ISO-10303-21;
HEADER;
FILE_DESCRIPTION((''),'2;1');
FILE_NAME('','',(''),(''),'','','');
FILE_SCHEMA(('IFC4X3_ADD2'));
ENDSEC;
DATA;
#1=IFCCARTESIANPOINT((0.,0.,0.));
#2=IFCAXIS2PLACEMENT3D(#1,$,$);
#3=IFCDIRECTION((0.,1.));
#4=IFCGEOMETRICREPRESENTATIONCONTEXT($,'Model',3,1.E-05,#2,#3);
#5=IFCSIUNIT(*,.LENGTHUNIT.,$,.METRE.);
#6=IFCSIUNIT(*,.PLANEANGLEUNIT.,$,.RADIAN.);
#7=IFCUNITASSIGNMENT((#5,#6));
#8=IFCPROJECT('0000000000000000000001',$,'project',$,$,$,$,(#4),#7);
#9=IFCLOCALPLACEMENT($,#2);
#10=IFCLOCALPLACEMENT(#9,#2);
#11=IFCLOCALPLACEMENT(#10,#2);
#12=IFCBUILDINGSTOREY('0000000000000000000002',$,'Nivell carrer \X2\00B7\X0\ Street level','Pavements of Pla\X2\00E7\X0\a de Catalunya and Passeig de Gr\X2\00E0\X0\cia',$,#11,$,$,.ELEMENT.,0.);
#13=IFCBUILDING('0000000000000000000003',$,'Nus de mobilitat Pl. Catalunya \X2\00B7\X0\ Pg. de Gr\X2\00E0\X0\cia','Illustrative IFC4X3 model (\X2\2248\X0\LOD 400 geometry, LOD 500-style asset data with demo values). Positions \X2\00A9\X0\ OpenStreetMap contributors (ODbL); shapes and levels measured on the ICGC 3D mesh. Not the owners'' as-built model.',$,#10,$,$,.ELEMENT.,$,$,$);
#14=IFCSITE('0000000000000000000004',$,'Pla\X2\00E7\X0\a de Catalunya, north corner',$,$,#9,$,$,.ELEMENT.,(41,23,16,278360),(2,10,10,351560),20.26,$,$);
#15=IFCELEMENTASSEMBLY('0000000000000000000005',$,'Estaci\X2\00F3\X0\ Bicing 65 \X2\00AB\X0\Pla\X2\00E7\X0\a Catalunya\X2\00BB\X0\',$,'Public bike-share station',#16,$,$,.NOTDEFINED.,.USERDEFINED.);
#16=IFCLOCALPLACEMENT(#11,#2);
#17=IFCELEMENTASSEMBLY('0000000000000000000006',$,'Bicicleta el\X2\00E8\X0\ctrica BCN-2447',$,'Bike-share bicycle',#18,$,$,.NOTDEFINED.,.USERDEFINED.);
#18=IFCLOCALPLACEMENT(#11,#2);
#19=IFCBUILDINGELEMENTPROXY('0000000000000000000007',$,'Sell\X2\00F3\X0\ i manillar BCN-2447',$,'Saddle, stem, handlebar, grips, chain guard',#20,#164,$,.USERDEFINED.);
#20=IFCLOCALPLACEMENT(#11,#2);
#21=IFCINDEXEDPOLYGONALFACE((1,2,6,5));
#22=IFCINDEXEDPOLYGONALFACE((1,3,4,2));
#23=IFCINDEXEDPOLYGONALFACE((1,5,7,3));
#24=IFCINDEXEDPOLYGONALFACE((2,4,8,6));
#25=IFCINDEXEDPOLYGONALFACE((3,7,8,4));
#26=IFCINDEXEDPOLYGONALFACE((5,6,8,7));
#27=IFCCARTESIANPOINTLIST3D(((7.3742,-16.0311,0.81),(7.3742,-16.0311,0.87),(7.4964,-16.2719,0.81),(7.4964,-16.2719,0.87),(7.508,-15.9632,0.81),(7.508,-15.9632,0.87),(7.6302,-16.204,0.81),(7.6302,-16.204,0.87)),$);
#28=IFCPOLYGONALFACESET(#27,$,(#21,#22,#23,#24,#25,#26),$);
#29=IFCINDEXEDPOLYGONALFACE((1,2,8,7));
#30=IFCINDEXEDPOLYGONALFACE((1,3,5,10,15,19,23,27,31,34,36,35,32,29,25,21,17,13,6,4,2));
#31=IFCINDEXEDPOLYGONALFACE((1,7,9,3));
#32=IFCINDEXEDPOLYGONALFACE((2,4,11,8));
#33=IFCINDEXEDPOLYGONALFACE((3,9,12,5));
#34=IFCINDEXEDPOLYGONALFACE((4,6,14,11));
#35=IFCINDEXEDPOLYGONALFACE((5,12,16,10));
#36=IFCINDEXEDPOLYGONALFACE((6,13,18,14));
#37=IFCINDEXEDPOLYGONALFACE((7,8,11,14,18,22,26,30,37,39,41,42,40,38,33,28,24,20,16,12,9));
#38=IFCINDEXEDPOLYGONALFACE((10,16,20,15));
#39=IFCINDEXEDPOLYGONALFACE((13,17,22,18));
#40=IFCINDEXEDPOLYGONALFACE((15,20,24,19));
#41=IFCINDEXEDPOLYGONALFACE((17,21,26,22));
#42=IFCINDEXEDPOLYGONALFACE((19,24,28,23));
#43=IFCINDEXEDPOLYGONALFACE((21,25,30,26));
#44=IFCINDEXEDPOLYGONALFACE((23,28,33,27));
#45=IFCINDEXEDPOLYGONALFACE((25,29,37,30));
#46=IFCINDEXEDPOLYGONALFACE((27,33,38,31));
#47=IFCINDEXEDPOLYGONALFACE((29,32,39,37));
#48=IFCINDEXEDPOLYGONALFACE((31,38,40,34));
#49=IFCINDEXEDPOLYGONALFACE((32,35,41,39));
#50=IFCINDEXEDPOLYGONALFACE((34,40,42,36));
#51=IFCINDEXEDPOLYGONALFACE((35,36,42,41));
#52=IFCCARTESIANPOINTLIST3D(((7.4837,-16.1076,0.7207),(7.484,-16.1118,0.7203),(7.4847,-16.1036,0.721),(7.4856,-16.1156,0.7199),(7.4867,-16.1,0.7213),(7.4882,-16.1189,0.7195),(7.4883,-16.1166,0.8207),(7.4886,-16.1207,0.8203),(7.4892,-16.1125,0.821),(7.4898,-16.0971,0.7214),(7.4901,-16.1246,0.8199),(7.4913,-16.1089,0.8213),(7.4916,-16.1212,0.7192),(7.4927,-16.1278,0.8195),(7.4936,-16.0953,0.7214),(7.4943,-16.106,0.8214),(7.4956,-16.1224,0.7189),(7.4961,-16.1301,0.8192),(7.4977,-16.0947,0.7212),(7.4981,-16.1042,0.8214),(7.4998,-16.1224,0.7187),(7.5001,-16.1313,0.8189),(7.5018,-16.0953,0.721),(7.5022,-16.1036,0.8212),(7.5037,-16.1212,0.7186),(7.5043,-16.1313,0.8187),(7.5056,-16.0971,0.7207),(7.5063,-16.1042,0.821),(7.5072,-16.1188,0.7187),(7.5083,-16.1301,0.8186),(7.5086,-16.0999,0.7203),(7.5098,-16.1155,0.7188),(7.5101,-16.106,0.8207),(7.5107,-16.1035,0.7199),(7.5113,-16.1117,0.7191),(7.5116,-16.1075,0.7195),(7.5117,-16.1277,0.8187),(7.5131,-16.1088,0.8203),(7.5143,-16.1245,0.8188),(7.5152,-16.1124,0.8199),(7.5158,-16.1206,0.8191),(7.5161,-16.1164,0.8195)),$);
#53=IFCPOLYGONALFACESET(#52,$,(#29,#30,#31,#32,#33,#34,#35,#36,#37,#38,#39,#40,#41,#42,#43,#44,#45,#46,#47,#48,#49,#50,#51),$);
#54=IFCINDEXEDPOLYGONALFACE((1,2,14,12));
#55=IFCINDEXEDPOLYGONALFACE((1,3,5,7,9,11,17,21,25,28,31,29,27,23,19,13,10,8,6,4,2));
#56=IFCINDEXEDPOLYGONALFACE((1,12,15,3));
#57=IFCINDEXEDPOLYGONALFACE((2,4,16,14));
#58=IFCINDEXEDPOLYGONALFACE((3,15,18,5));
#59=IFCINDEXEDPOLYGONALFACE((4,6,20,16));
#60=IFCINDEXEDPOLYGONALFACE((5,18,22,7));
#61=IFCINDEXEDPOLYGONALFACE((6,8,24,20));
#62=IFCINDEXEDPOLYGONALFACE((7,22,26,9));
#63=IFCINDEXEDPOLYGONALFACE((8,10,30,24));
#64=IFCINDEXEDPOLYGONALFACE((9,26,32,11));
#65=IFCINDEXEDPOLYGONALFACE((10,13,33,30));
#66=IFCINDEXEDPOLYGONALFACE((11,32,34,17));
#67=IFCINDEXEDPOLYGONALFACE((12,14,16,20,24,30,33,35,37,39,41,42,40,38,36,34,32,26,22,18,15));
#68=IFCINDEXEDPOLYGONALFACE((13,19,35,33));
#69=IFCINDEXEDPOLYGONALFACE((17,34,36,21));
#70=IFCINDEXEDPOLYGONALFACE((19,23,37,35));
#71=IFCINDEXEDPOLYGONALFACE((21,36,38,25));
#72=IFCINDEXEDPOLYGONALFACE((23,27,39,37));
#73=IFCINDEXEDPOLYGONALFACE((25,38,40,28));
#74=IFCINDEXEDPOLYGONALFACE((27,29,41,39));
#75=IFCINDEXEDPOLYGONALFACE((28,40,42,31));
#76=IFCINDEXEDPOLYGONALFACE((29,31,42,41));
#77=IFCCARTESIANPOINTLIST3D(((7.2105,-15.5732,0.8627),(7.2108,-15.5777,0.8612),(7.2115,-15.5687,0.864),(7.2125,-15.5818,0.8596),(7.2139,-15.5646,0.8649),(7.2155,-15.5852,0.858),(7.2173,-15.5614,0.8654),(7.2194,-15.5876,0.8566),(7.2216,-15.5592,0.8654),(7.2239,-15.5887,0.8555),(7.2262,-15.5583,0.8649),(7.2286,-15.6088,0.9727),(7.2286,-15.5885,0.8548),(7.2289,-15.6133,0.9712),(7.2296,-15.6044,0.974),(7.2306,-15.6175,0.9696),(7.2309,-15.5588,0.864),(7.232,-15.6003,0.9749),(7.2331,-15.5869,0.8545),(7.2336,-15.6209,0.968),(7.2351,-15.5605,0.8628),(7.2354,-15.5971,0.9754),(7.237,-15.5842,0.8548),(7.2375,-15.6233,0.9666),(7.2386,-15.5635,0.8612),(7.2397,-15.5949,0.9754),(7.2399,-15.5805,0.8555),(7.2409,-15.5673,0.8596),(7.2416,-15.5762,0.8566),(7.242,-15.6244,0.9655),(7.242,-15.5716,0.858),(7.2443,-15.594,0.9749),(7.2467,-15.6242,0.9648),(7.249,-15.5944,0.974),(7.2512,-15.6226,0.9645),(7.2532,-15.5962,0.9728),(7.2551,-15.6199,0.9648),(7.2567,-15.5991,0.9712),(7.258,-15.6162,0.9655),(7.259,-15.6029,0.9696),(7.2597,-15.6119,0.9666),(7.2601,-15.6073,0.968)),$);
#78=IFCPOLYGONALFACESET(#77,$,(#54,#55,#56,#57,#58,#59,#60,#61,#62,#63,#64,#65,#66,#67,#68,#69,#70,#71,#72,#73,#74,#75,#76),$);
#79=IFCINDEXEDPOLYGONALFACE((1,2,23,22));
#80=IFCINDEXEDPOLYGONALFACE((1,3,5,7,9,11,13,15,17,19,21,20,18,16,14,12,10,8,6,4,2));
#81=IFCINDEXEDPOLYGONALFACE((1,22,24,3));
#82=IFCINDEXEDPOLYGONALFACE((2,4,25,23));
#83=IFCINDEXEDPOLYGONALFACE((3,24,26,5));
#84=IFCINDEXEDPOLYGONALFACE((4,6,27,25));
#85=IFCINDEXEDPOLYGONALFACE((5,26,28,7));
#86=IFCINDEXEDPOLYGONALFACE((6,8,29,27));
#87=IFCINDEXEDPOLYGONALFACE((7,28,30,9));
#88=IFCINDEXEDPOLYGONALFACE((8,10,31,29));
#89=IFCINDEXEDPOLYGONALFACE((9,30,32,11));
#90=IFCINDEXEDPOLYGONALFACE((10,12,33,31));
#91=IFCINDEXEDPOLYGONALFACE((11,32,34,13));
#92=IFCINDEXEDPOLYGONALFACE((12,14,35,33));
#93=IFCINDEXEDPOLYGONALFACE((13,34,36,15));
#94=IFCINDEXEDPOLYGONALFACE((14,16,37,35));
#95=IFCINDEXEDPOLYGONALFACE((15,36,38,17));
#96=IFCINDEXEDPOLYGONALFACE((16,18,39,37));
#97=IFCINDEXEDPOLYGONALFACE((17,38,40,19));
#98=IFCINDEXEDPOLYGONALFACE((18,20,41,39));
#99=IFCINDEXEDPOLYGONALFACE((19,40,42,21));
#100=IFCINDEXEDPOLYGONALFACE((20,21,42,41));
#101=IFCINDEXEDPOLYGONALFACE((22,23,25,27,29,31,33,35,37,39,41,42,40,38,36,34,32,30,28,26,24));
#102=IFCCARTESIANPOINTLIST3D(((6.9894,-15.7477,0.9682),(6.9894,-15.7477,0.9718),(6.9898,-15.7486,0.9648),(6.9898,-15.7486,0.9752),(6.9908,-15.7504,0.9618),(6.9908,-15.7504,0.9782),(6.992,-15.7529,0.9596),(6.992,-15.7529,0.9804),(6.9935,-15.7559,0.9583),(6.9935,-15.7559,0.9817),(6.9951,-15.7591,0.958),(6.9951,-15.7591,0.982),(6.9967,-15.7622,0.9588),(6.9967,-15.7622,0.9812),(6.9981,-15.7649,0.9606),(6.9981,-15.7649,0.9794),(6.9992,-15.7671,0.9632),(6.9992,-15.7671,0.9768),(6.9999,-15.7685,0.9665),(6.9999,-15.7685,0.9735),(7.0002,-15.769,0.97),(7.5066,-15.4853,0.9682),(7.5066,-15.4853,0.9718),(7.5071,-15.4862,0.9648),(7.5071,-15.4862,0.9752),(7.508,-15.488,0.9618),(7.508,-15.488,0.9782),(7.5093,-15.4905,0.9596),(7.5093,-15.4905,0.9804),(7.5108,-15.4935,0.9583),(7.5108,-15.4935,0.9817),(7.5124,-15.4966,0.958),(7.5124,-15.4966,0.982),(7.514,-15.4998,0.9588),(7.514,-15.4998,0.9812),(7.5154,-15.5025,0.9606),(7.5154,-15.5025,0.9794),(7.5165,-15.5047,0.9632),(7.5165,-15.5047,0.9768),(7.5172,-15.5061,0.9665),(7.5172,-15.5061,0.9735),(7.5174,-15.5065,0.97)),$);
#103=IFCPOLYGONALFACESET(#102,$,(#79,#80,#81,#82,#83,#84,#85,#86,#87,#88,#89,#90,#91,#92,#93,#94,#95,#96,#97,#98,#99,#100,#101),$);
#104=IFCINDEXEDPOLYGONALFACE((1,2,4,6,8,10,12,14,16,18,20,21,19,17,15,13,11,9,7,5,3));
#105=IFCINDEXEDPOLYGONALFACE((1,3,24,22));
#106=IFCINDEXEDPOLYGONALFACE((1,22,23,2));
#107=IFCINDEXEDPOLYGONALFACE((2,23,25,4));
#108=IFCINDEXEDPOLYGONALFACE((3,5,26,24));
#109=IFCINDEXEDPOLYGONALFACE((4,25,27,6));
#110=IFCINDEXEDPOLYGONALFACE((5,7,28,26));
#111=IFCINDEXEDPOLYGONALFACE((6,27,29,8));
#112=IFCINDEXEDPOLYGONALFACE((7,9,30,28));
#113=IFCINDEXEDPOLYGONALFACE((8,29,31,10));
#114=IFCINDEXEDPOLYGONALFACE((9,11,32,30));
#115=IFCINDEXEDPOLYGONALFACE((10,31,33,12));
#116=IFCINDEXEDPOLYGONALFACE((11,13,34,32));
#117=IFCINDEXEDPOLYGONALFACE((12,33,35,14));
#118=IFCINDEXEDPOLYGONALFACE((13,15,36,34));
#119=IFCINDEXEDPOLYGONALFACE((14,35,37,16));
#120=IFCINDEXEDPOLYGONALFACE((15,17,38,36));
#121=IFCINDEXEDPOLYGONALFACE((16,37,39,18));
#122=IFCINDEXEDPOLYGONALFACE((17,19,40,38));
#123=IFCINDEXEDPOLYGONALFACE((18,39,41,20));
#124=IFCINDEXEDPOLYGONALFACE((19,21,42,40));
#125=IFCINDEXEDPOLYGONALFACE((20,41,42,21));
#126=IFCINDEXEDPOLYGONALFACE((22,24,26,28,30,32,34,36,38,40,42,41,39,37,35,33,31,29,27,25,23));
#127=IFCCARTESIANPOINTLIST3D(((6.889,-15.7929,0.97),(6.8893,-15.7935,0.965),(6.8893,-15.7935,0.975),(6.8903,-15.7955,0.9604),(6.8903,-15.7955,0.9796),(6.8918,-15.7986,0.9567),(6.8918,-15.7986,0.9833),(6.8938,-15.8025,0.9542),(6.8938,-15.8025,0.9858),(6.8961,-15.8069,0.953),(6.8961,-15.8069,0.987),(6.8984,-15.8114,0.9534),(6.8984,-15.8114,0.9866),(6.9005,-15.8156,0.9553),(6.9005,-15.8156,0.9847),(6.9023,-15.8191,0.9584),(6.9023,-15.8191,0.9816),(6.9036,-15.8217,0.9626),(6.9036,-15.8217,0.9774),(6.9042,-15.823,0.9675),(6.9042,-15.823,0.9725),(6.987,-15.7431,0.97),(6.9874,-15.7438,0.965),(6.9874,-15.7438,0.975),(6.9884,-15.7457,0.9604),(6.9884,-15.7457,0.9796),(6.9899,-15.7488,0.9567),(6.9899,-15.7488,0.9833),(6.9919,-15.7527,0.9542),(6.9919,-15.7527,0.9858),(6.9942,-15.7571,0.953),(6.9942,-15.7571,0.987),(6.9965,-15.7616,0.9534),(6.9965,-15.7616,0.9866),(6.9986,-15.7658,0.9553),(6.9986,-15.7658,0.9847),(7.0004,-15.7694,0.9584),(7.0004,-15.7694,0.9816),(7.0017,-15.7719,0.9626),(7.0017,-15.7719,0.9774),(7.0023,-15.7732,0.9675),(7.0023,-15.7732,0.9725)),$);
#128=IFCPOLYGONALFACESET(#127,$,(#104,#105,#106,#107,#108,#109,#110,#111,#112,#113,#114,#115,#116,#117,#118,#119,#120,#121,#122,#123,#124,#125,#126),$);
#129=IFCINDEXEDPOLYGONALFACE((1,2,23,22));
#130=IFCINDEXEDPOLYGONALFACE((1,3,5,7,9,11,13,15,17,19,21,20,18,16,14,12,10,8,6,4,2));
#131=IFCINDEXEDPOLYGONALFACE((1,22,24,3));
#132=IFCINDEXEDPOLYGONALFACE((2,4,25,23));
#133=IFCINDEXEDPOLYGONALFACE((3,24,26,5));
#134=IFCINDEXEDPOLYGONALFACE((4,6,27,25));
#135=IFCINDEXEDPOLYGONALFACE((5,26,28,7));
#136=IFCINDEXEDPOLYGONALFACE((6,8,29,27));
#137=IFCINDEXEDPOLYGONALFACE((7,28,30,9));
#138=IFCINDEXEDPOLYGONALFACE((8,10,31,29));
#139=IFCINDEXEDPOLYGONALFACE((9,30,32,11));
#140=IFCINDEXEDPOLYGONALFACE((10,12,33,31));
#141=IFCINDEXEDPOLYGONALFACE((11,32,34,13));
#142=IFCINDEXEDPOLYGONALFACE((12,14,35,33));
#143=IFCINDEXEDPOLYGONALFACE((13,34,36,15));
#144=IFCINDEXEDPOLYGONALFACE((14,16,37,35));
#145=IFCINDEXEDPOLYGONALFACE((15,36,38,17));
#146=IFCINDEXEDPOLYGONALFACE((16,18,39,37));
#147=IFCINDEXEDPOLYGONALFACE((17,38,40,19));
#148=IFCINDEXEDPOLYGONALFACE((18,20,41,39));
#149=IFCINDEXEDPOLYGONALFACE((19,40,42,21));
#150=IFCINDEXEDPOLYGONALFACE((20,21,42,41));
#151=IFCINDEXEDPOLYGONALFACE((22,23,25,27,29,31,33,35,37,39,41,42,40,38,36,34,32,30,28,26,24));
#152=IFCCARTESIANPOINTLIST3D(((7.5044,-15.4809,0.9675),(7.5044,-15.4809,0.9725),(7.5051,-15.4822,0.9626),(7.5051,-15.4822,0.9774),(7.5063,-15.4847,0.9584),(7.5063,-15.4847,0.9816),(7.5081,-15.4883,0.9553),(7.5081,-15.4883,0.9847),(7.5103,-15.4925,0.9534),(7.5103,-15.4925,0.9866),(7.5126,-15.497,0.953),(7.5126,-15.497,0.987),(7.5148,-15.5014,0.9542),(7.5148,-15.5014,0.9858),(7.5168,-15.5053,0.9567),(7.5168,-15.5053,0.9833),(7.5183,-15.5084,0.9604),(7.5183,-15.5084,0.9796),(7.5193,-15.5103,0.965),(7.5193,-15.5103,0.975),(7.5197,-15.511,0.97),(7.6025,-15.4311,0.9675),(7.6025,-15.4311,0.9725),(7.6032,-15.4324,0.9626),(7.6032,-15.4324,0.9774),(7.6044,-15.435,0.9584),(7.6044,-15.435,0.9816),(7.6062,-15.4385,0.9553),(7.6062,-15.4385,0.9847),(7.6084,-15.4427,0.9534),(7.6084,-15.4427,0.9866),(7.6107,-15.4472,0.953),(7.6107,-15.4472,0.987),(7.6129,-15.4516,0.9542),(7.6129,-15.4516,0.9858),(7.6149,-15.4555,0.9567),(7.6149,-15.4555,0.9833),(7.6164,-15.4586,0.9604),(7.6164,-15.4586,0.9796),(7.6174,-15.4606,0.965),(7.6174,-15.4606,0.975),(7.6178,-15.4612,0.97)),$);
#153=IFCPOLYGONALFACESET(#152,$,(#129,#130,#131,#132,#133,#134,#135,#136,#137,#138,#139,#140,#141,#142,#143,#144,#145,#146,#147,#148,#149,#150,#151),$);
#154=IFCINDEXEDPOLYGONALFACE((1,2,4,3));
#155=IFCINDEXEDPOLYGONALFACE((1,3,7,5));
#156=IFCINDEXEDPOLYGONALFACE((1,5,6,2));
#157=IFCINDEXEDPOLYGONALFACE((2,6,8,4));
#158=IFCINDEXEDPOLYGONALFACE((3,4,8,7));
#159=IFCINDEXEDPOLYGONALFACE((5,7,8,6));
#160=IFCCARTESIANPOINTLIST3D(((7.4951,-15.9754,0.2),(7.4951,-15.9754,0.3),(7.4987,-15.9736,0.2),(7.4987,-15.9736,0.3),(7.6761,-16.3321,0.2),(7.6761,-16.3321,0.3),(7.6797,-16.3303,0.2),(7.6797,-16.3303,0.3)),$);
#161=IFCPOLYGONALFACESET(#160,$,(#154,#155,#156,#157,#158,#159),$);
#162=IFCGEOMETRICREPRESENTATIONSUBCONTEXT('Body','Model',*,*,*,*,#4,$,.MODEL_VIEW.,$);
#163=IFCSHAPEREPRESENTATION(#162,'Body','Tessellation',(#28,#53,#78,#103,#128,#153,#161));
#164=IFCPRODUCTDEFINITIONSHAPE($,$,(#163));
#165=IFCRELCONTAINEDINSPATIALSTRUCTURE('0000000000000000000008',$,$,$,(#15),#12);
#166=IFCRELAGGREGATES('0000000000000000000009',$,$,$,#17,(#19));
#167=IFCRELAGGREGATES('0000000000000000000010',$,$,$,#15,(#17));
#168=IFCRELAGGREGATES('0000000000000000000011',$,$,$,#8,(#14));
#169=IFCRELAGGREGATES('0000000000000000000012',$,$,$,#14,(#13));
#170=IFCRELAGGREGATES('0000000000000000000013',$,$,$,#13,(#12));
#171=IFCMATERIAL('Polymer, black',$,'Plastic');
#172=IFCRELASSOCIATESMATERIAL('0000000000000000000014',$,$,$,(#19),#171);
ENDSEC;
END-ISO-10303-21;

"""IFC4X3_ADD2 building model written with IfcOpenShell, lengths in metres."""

from ifc_helpers import new_model, si_unit, direction, frame, origin, origin_2d_with_axis, place, context, subcontext, project, spatial, rectangle, circle, extrude, material, element, aggregate, save


model = new_model("IFC4X3_ADD2")

# Units and contexts
model_context = context("Model", 3, precision=1e-05, world=origin(), true_north=direction((0.0, 1.0)))
body_context = subcontext(model_context, "Body", "Model", "MODEL_VIEW")
ifc_project = project(units=[si_unit("LENGTHUNIT", "METRE"), si_unit("PLANEANGLEUNIT", "RADIAN")], contexts=[model_context])

# Site, building, storey
site_placement = place(None, origin())
site = spatial("IfcSite", under=ifc_project, at=site_placement, Name="Plaça de Catalunya, north corner", CompositionType="ELEMENT", RefLatitude=(41, 23, 16, 278360), RefLongitude=(2, 10, 10, 351560), RefElevation=20.26)
building_placement = place(site_placement, origin())
building = spatial("IfcBuilding", under=site, at=building_placement, Name="Nus de mobilitat Pl. Catalunya · Pg. de Gràcia", Description="Illustrative IFC4X3 model (≈LOD 400 geometry, LOD 500-style asset data with demo values). Positions © OpenStreetMap contributors (ODbL); shapes and levels measured on the ICGC 3D mesh. Not the owners' as-built model.", CompositionType="ELEMENT")
storey_placement = place(building_placement, origin())
storey = spatial("IfcBuildingStorey", under=building, at=storey_placement, Name="Nivell carrer · Street level", Description="Pavements of Plaça de Catalunya and Passeig de Gràcia", CompositionType="ELEMENT", Elevation=0.0)

# Element assemblies, building element proxy
assembly_1_placement = place(building_placement, origin())
assembly_1 = element("IfcElementAssembly", 1, at=assembly_1_placement, inside=storey, Name="Estació Bicing 65 «Plaça Catalunya»", ObjectType="Public bike-share station", AssemblyPlace="NOTDEFINED", PredefinedType="USERDEFINED")
assembly_2_placement = place(building_placement, origin())
assembly_2 = element("IfcElementAssembly", 2, at=assembly_2_placement, Name="Bicicleta elèctrica BCN-2447", ObjectType="Bike-share bicycle", AssemblyPlace="NOTDEFINED", PredefinedType="USERDEFINED")
ifc_material_1 = material(Name="Polymer, black", Category="Plastic")
proxy_1_placement = place(building_placement, origin())
proxy_1 = element("IfcBuildingElementProxy", 3, at=proxy_1_placement, material=ifc_material_1, Name="Selló i manillar BCN-2447", ObjectType="Saddle, stem, handlebar, grips, chain guard", PredefinedType="USERDEFINED", context=body_context, shape_type="SweptSolid", body=[
    extrude(rectangle(XDim=0.27, YDim=0.15, at=origin_2d_with_axis()), frame((7.5022, -16.1175, 0.87), z_axis=(0.0, 0.0, -1.0), x_axis=(-0.452435, 0.891798, 0.0)), (0.0, 0.0, 1.0), 0.06),
    extrude(circle(Radius=0.014, at=origin_2d_with_axis()), frame((7.4977, -16.1086, 0.72), z_axis=(0.045019, -0.088737, 0.995037), x_axis=(0.0, 0.996047, 0.088827)), (0.0, 0.0, 1.0), 0.1005),
    extrude(circle(Radius=0.016, at=origin_2d_with_axis()), frame((7.2262, -15.5735, 0.86), z_axis=(0.154616, -0.304766, 0.939793), x_axis=(0.0, 0.951232, 0.308475)), (0.0, 0.0, 1.0), 0.117),
    extrude(circle(Radius=0.012, at=origin_2d_with_axis()), frame((6.9947, -15.7583, 0.97), z_axis=(0.891798, 0.452435, 0.0), x_axis=(0.452435, -0.891798, 0.0)), (0.0, 0.0, 1.0), 0.58),
    extrude(circle(Radius=0.017, at=origin_2d_with_axis()), frame((6.9947, -15.7583, 0.97), z_axis=(-0.891798, -0.452435, 0.0), x_axis=(-0.452435, 0.891798, 0.0)), (0.0, 0.0, 1.0), 0.11),
    extrude(circle(Radius=0.017, at=origin_2d_with_axis()), frame((7.512, -15.4958, 0.97), z_axis=(0.891798, 0.452435, 0.0), x_axis=(0.452435, -0.891798, 0.0)), (0.0, 0.0, 1.0), 0.11),
    extrude(rectangle(XDim=0.4, YDim=0.1, at=origin_2d_with_axis()), frame((7.5856, -16.1537, 0.25), z_axis=(0.891798, 0.452435, 0.0), x_axis=(-0.452435, 0.891798, 0.0)), (0.0, 0.0, 1.0), 0.004),
])
aggregate(assembly_2, [proxy_1])
aggregate(assembly_1, [assembly_2])

save(model, "model.ifc")
